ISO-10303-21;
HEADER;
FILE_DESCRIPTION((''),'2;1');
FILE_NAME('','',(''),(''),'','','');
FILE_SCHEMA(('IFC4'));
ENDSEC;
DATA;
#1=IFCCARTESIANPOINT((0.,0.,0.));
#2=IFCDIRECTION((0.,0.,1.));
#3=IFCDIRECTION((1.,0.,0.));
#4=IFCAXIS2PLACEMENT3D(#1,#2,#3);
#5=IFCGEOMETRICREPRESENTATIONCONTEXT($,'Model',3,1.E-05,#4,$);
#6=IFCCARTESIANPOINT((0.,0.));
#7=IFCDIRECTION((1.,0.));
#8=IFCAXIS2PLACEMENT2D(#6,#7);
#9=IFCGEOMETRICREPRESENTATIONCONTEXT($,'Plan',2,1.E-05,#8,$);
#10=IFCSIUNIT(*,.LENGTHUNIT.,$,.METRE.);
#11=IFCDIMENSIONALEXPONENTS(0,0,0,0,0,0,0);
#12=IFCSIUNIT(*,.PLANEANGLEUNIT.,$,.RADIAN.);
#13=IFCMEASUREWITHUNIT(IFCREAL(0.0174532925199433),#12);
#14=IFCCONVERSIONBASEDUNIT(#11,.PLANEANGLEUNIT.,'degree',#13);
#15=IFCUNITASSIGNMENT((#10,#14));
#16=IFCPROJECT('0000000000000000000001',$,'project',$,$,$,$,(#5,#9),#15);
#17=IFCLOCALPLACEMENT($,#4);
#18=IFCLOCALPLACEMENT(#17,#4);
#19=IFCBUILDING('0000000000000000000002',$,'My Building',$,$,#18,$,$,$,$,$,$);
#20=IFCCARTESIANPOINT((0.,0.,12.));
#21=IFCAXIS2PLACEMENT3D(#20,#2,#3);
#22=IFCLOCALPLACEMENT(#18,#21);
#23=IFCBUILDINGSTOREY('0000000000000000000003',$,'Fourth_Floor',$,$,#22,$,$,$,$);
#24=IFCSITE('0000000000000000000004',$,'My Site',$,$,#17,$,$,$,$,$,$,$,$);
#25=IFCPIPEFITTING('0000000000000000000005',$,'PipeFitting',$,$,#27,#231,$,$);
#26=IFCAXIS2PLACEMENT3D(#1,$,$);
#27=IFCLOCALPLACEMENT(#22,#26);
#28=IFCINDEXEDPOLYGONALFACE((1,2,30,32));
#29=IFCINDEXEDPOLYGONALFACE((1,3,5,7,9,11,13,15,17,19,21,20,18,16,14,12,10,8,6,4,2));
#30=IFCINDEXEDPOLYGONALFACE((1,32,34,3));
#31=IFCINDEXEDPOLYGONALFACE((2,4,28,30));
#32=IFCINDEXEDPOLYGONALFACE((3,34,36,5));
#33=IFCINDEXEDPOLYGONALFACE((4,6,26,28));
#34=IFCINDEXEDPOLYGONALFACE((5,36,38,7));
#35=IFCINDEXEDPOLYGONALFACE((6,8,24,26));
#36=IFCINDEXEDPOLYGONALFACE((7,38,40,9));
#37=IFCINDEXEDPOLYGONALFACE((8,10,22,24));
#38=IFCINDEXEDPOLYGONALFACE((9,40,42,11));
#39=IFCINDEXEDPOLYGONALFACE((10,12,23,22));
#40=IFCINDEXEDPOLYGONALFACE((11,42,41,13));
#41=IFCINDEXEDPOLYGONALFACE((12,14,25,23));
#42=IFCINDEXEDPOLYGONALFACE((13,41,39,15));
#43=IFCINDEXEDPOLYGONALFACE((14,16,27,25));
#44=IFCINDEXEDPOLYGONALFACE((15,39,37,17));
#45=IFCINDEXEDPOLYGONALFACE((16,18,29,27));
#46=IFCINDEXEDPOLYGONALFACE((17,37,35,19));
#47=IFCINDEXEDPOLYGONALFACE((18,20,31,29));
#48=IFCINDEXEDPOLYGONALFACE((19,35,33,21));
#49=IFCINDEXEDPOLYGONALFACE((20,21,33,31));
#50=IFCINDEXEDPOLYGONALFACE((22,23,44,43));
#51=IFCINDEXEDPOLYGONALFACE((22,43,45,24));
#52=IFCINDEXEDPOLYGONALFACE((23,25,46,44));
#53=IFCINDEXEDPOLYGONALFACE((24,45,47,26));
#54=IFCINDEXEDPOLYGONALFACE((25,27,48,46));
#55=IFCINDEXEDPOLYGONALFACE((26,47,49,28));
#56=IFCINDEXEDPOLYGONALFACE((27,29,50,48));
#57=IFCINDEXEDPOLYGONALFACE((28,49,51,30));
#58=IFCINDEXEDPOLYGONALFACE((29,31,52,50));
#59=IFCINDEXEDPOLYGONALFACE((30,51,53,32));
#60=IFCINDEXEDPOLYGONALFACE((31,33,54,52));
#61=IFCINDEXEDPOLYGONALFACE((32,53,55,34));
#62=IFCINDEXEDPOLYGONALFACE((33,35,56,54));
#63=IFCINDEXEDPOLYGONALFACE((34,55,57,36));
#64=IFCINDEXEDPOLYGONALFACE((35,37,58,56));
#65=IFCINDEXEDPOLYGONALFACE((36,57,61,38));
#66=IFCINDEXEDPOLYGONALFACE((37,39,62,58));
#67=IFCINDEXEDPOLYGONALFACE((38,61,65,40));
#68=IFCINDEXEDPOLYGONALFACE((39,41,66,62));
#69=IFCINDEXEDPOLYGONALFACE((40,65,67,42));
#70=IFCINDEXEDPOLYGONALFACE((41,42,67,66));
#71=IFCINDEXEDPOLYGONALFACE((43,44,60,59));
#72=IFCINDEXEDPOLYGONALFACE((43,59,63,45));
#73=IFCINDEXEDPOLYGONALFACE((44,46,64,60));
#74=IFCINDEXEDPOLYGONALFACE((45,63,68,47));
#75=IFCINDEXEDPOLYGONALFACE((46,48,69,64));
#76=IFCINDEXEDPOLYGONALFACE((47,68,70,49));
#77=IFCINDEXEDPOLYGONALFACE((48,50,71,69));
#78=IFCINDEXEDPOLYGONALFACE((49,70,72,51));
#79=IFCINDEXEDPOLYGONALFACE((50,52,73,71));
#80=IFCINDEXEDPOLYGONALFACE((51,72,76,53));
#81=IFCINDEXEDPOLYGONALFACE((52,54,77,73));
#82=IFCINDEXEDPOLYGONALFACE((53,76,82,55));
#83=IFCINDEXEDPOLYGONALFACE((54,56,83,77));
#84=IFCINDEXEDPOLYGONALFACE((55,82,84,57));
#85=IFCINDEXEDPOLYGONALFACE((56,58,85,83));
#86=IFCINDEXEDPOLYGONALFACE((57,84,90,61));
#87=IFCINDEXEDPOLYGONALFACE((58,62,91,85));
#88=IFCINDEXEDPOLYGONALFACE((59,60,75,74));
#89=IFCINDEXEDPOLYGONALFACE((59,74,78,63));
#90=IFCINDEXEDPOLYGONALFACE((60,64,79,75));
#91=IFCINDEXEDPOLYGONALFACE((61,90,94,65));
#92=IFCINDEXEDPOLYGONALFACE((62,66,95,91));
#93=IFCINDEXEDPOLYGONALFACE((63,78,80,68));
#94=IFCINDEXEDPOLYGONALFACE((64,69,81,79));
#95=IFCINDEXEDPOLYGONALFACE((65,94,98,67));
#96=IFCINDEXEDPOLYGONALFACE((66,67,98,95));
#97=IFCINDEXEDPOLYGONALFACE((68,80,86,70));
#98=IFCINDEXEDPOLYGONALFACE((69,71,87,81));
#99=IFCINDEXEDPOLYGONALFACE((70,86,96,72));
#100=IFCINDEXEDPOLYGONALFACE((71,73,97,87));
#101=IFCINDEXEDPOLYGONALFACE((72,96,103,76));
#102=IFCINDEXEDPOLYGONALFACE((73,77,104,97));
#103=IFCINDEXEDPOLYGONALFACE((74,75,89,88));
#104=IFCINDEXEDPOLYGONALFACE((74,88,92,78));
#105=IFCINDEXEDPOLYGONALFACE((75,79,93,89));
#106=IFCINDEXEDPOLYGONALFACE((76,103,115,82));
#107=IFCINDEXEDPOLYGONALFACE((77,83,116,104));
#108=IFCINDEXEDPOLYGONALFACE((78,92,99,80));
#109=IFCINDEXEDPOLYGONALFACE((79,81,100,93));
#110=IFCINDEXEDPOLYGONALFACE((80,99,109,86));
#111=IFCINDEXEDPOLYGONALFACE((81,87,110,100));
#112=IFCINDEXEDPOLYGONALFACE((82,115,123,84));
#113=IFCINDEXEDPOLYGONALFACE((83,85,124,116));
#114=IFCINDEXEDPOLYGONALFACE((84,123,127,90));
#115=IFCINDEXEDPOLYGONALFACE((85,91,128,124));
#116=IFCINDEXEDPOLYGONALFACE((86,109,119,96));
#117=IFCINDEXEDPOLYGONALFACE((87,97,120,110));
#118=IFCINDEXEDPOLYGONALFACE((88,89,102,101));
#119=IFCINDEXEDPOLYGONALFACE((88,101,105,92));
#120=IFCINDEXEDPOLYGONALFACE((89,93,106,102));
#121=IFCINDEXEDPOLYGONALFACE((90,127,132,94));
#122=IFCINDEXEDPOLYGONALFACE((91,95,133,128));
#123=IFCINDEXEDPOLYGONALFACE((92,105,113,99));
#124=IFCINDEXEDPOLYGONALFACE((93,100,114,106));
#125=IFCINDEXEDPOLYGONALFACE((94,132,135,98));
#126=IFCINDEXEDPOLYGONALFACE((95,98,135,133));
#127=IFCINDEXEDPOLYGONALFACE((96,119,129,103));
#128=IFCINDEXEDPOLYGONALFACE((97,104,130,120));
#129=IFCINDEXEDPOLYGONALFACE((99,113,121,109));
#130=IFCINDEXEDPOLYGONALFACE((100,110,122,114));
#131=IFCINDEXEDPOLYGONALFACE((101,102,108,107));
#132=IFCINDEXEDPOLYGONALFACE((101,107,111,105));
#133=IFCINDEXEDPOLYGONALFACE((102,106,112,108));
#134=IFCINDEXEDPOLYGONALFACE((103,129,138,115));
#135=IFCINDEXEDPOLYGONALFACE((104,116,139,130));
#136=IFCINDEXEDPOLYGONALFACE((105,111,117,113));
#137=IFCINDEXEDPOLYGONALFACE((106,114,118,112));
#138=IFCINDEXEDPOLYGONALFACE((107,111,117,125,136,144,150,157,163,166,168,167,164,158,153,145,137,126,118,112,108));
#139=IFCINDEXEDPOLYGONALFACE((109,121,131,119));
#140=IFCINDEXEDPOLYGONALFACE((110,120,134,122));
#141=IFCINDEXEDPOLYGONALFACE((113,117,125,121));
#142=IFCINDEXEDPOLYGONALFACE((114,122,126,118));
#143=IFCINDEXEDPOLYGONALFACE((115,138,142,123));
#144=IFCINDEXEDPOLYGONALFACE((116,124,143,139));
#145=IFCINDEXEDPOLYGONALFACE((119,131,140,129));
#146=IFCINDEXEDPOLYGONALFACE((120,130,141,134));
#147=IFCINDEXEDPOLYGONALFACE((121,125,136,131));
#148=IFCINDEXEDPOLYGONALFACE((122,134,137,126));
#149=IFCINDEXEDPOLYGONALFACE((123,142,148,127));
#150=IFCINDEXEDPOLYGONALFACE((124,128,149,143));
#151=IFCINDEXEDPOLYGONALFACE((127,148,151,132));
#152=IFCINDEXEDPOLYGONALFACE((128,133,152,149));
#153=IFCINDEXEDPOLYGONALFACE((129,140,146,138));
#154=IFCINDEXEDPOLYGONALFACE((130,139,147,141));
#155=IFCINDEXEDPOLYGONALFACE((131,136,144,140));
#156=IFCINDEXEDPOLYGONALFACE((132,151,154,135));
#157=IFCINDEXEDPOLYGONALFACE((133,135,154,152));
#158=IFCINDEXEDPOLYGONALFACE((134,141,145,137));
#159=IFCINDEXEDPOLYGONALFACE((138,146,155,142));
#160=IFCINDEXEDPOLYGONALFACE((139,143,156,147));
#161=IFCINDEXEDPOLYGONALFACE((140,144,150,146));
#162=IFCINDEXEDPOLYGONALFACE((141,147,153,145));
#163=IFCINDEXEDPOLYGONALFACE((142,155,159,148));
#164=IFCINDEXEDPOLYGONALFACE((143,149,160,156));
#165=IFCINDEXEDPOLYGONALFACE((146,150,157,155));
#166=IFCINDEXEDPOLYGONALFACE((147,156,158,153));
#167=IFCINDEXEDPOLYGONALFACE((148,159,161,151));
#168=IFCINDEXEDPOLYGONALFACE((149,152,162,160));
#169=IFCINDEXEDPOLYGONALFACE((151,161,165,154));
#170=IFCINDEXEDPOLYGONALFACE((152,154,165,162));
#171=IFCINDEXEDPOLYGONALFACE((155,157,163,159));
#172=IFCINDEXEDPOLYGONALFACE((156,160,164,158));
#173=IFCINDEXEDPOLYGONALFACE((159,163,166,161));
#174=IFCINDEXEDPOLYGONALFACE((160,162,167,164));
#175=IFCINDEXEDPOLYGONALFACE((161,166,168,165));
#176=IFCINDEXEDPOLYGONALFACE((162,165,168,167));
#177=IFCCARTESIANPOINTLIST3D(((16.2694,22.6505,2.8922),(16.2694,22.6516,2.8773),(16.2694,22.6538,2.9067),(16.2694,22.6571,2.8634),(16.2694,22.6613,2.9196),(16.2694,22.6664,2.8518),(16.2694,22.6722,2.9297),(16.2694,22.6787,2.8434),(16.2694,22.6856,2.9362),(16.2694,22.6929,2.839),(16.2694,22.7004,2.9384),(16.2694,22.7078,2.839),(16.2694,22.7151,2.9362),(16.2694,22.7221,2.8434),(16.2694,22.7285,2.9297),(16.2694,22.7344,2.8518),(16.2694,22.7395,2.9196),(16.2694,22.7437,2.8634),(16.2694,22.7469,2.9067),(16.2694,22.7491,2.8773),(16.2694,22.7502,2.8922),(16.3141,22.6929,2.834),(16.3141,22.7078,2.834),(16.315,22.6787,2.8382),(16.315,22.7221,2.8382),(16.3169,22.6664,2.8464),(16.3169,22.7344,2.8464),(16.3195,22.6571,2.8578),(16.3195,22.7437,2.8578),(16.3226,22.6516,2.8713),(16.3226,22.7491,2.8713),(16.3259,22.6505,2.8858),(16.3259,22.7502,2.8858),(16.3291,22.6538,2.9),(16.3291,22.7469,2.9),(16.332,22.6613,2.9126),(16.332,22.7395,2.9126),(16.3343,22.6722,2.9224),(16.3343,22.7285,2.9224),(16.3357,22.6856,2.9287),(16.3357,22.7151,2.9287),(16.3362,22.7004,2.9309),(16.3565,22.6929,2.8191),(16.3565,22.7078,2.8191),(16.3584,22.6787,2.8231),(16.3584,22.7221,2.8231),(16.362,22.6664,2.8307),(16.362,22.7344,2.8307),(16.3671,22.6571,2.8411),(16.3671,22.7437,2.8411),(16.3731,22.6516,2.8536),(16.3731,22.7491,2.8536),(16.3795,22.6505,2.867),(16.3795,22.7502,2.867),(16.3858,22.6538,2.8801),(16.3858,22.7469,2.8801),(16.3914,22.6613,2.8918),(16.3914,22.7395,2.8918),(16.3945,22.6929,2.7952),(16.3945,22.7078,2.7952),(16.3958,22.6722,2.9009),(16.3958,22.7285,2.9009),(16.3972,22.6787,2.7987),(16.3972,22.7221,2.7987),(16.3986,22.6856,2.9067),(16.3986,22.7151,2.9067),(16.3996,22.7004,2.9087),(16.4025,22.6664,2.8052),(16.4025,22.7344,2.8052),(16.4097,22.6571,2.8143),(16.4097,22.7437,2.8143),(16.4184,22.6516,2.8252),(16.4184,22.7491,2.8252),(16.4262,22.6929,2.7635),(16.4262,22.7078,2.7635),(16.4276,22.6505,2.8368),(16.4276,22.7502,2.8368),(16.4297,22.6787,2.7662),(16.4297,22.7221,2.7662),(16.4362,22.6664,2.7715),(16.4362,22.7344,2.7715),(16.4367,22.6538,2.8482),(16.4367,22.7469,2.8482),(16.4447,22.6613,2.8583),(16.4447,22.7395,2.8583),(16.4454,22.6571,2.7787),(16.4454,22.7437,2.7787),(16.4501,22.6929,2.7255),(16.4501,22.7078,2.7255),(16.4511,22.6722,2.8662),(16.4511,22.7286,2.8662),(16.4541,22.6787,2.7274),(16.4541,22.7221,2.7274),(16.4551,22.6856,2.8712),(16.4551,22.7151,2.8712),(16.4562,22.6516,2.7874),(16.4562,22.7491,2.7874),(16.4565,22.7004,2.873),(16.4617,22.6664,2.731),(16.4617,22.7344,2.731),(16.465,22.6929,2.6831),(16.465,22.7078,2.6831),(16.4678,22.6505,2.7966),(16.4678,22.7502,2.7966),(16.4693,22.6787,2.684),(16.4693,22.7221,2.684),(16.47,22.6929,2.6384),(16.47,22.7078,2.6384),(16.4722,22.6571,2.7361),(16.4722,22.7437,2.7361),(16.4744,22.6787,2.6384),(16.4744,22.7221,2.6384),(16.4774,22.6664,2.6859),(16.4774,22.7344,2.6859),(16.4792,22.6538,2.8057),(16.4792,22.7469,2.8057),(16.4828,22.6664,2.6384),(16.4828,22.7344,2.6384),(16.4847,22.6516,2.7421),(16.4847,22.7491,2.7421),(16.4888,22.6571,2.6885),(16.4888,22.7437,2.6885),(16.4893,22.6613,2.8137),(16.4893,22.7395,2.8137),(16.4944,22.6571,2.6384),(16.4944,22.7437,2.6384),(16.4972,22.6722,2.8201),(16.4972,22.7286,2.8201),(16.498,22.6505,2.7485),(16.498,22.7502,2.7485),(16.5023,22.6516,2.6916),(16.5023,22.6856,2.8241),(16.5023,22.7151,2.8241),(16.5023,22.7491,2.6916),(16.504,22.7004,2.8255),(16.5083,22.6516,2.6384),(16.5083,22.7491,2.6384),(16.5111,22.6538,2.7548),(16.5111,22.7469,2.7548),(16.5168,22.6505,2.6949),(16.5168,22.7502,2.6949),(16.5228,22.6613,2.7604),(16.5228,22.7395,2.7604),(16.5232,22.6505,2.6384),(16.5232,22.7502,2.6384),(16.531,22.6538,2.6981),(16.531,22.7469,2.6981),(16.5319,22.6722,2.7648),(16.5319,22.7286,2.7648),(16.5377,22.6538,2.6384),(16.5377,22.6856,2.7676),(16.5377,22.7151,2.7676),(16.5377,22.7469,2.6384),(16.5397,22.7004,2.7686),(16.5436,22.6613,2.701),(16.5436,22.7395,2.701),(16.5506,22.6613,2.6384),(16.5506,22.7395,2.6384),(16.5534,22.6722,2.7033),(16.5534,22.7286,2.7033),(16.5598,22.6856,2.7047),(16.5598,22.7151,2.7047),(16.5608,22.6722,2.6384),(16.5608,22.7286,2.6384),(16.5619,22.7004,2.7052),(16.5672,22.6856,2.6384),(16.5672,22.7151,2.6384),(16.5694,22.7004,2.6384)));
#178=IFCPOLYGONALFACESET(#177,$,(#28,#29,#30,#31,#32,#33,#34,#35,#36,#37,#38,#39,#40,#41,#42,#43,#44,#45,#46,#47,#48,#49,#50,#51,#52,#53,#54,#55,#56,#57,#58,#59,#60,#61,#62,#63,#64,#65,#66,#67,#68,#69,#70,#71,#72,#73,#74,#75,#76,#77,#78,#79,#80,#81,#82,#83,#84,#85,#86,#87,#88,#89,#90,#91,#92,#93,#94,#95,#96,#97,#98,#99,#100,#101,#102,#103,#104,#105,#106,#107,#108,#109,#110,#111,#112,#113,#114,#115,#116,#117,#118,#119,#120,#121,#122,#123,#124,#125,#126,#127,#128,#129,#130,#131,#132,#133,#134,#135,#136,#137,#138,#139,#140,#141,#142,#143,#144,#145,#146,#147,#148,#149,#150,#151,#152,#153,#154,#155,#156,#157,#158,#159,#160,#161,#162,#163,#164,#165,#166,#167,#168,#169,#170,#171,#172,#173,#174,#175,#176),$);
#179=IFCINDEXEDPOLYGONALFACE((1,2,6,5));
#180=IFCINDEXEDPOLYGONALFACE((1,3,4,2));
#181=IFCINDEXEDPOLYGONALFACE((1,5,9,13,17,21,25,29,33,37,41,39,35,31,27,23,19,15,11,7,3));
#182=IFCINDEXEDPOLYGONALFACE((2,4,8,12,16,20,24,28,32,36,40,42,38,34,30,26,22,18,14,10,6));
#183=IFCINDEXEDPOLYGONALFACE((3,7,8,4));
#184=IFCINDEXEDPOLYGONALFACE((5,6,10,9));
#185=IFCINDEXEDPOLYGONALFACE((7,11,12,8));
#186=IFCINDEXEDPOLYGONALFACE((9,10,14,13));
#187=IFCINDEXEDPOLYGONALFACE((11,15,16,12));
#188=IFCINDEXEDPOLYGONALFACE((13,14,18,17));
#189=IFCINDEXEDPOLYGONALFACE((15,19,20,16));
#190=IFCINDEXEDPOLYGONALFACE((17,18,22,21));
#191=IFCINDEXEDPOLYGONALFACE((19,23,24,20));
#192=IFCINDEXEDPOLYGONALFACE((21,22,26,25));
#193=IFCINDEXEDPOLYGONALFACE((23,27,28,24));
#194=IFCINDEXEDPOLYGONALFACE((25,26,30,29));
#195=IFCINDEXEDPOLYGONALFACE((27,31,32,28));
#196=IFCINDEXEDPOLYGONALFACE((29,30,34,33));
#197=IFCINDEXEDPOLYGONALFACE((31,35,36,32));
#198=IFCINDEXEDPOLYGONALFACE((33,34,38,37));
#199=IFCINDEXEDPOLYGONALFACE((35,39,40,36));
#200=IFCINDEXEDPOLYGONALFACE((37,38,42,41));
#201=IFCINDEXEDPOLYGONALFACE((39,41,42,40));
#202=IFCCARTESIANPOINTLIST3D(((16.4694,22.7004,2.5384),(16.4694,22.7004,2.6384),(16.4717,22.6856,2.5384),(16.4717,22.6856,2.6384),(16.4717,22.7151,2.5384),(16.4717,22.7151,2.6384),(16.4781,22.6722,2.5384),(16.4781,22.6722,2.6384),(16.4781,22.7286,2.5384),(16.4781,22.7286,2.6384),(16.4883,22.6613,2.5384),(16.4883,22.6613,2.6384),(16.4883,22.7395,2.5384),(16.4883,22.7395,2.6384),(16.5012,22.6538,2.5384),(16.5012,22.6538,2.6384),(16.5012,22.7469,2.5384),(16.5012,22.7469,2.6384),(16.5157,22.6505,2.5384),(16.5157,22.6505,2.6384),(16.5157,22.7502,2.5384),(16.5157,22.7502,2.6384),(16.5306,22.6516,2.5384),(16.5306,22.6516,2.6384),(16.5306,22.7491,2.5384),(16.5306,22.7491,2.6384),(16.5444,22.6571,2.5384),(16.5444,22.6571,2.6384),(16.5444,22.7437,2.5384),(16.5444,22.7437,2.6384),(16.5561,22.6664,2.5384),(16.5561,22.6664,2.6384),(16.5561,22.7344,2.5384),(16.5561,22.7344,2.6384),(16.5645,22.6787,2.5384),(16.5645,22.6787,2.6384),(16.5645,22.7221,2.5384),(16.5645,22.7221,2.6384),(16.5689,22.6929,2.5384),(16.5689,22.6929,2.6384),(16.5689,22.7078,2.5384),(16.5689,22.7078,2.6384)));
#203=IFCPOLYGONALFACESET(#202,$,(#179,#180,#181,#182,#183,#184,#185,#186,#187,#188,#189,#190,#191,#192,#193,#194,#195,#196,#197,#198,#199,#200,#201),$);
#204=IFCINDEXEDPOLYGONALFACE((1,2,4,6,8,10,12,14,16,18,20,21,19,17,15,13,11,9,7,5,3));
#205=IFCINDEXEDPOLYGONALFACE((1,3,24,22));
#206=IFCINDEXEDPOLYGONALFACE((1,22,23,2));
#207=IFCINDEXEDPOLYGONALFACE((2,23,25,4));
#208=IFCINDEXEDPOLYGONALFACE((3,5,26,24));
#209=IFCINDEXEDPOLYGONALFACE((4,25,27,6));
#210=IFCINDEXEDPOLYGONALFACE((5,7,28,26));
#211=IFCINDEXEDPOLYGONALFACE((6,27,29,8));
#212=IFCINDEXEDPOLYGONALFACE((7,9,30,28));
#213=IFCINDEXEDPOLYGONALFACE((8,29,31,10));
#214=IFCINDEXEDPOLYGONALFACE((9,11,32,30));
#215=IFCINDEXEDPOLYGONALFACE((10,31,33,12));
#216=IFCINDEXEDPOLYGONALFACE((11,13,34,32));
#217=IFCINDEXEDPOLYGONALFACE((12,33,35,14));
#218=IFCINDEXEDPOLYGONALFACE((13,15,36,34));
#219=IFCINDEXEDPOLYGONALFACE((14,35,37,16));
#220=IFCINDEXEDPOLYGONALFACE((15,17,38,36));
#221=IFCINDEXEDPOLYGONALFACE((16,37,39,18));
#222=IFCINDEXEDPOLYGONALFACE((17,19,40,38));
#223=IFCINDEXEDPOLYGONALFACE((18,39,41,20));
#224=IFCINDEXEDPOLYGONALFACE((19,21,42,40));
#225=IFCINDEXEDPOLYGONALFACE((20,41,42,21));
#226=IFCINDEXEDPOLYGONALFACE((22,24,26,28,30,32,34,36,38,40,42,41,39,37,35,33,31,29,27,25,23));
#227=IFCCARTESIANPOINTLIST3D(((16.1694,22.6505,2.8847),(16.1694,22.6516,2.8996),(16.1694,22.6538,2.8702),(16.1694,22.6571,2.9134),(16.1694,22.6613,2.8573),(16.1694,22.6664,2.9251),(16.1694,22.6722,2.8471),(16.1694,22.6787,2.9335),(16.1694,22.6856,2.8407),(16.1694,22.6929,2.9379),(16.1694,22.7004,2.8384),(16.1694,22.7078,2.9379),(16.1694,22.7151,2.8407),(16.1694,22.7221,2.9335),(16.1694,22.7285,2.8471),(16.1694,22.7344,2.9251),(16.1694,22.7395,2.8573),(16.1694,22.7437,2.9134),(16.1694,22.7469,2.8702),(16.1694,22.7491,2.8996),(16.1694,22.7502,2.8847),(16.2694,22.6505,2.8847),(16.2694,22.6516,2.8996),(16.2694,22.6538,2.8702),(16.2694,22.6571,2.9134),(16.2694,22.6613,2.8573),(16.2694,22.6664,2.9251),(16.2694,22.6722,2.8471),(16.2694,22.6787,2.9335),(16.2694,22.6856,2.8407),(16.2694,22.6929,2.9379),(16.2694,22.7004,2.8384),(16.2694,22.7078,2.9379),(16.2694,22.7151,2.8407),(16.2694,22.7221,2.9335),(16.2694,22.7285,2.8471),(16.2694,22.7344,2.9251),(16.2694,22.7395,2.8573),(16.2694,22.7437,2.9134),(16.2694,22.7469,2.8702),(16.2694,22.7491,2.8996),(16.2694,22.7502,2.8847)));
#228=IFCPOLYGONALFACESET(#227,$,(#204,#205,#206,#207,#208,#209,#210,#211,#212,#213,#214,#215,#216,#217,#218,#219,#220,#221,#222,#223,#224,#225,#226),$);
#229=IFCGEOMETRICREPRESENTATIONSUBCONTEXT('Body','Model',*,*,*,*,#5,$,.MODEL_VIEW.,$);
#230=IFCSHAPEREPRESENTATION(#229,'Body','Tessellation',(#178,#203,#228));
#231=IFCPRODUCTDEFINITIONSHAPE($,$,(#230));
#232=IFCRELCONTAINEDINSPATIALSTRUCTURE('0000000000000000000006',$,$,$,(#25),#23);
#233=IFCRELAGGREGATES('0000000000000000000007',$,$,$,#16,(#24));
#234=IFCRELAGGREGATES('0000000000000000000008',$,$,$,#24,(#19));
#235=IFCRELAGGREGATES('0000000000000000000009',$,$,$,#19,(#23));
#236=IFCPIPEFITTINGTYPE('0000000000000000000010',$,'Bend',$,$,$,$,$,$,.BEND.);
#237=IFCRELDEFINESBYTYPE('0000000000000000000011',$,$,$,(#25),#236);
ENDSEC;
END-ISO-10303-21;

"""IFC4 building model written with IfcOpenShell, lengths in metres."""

from ifc_helpers import new_model, entity, si_unit, converted_unit, frame, origin_with_axes, origin_2d_with_axis, place, context, subcontext, project, spatial, circle, extrude, source, transform, mapped, type_object, type_shapes, element, save


model = new_model("IFC4")

# Units and contexts
model_context = context("Model", 3, precision=1e-05, world=origin_with_axes())
plan_context = context("Plan", 2, precision=1e-05, world=origin_2d_with_axis())
body_context = subcontext(model_context, "Body", "Model", "MODEL_VIEW")
ifc_project = project(units=[si_unit("LENGTHUNIT", "METRE"), converted_unit("PLANEANGLEUNIT", "degree", entity("IfcReal", 0.0174532925199433), si_unit("PLANEANGLEUNIT", "RADIAN"), dimensions=[0, 0, 0, 0, 0, 0, 0])], contexts=[model_context, plan_context])

# Site, building, storey
site_placement = place(None, origin_with_axes())
site = spatial("IfcSite", under=ifc_project, at=site_placement, Name="My Site")
building_placement = place(site_placement, origin_with_axes())
building = spatial("IfcBuilding", under=site, at=building_placement, Name="My Building")
storey_placement = place(building_placement, frame((0.0, 0.0, 12.0), z_axis=(0.0, 0.0, 1.0), x_axis=(1.0, 0.0, 0.0)))
storey = spatial("IfcBuildingStorey", under=building, at=storey_placement, Name="Fourth_Floor")

# Pipe fitting
pipe_fitting_type = type_object("IfcPipeFittingType", Name="Bend", PredefinedType="BEND")
shared_shape = source(origin_with_axes(), body_context, "Body", "SolidModel", [
    entity("IfcSweptDiskSolid", entity("IfcIndexedPolyCurve", entity("IfcCartesianPointList3D", [[0.0, 0.0, -0.1], [0.0732, 0.0, -0.2768], [0.25, 0.0, -0.35]]), [entity("IfcArcIndex", [1, 2, 3])]), 0.05),
    extrude(circle(Radius=0.05), origin_with_axes(), (0.0, 0.0, -1.0), 0.1),
    extrude(circle(Radius=0.05), frame((0.25, 0.0, -0.35), z_axis=(1.0, 0.0, 0.0), x_axis=(0.0, 0.0, 1.0)), (0.0, 0.0, 1.0), 0.1),
])
type_shapes(pipe_fitting_type, [shared_shape])
for number, where, z_axis, x_axis, name in (
    (1, (16.5194, 22.7004, 2.5384), (0.000001, 0.0, -1.0), (-1.0, -0.000001, -0.000001), "PipeFitting"),
):
    element("IfcPipeFitting", number, at=place(storey_placement, frame(where, z_axis=z_axis, x_axis=x_axis)), inside=storey, type_object=pipe_fitting_type, Name=name, context=body_context, shape_type="MappedRepresentation", body=[
        mapped(shared_shape, transform((0.0, 0.0, 0.0), x_axis=(1.0, 0.0, 0.0), y_axis=(0.0, 1.0, 0.0), z_axis=(0.0, 0.0, 1.0), scale=1.0)),
    ])

save(model, "model.ifc")
